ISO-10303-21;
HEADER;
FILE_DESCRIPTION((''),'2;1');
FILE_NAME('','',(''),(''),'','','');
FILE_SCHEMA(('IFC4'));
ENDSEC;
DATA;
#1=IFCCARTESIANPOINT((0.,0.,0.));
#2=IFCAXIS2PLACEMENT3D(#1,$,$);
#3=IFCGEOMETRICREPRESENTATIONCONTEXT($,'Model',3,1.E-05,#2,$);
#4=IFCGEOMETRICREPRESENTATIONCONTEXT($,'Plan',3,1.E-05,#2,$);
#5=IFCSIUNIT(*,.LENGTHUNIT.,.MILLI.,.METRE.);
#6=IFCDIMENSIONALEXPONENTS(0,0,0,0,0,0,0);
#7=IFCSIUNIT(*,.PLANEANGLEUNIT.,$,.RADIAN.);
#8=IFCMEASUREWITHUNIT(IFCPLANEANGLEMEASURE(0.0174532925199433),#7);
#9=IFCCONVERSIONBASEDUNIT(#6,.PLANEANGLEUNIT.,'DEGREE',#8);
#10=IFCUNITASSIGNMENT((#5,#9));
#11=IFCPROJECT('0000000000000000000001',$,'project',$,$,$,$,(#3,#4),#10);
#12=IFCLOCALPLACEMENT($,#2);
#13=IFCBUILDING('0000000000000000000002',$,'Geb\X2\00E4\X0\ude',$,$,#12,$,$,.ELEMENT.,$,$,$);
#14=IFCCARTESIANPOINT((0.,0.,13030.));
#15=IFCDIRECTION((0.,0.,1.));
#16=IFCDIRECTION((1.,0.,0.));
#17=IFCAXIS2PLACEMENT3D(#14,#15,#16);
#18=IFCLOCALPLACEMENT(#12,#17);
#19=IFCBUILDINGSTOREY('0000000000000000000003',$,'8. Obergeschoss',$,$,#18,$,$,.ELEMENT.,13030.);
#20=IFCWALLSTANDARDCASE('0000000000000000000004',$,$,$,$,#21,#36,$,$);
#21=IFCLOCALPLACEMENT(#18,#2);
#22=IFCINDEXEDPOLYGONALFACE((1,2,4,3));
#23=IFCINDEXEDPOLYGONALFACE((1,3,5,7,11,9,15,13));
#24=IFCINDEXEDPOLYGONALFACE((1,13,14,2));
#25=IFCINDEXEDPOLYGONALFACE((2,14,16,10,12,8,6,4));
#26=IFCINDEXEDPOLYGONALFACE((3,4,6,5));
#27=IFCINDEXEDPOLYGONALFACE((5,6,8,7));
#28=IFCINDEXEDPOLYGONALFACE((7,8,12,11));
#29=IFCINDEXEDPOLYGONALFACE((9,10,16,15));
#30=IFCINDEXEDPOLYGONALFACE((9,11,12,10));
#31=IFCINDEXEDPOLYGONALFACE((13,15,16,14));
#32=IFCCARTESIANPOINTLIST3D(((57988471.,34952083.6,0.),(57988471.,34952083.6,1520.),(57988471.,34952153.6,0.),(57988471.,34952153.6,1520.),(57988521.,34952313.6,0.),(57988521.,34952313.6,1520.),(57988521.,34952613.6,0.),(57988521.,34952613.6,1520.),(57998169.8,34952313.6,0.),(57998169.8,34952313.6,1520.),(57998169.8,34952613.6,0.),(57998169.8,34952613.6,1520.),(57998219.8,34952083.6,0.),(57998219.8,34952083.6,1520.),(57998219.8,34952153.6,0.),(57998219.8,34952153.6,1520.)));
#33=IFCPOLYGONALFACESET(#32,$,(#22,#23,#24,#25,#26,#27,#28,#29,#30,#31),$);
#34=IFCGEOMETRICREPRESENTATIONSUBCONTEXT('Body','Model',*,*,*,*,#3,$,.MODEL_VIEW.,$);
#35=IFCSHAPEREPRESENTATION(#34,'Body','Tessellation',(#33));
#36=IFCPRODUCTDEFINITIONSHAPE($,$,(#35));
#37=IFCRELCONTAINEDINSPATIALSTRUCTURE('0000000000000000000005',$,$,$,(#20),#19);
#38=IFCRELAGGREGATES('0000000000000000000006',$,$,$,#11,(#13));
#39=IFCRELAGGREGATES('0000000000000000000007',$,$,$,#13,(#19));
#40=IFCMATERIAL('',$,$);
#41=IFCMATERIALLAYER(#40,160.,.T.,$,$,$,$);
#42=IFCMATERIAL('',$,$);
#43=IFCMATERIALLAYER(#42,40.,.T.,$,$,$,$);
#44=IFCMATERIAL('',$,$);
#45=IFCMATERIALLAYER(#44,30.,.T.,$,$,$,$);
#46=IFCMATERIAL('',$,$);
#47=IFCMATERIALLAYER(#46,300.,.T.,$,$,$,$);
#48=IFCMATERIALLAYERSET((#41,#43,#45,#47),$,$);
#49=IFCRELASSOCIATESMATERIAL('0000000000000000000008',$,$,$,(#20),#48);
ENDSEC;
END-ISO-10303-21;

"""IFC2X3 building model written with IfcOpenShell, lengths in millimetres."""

from ifc_helpers import new_model, entity, si_unit, converted_unit, frame, origin, origin_with_axes, place, context, subcontext, project, spatial, polyline, outline, extrude, material, layer, layer_set, layer_usage, element, save


model = new_model("IFC2X3")

# Units and contexts
model_context = context("Model", 3, precision=1e-05, world=origin())
plan_context = context("Plan", 3, precision=1e-05, world=origin())
body_context = subcontext(model_context, "Body", "Model", "MODEL_VIEW")
ifc_project = project(units=[si_unit("LENGTHUNIT", "METRE", prefix="MILLI"), converted_unit("PLANEANGLEUNIT", "DEGREE", entity("IfcPlaneAngleMeasure", 0.0174532925199433), si_unit("PLANEANGLEUNIT", "RADIAN"), dimensions=[0, 0, 0, 0, 0, 0, 0])], contexts=[model_context, plan_context])

# Building, storey
building_placement = place(None, origin())
building = spatial("IfcBuilding", under=ifc_project, at=building_placement, Name="Gebäude", CompositionType="ELEMENT")
storey_placement = place(building_placement, frame((0.0, 0.0, 13030.0), z_axis=(0.0, 0.0, 1.0), x_axis=(1.0, 0.0, 0.0)))
storey = spatial("IfcBuildingStorey", under=building, at=storey_placement, Name="8. Obergeschoss", CompositionType="ELEMENT", Elevation=13030.0)

# Wall
ifc_material_1 = material(Name="")
ifc_layer_1 = layer(ifc_material_1, 160.0, ventilated=True)
ifc_material_2 = material(Name="")
ifc_layer_2 = layer(ifc_material_2, 40.0, ventilated=True)
ifc_material_3 = material(Name="")
ifc_layer_3 = layer(ifc_material_3, 30.0, ventilated=True)
ifc_material_4 = material(Name="")
ifc_layer_4 = layer(ifc_material_4, 300.0, ventilated=True)
ifc_layer_set_1 = layer_set([ifc_layer_1, ifc_layer_2, ifc_layer_3, ifc_layer_4])
ifc_layer_usage_1 = layer_usage(ifc_layer_set_1, "AXIS2", "POSITIVE", 0.0)
wall_1_placement = place(storey_placement, frame((57998169.8, 34952613.6, 0.0), z_axis=(0.0, 0.0, 1.0), x_axis=(-1.0, 0.0, 0.0)))
element("IfcWallStandardCase", 1, at=wall_1_placement, inside=storey, material=ifc_layer_usage_1, context=body_context, shape_type="SweptSolid", body=[
    extrude(outline(polyline([(0.0, 0.0), (9648.8, 0.0), (9648.8, 300.0), (9698.8, 460.0), (9698.8, 530.0), (-50.0, 530.0), (-50.0, 460.0), (0.0, 300.0), (0.0, 0.0)])), origin_with_axes(), (0.0, 0.0, 1.0), 1520.0),
])

save(model, "model.ifc")
